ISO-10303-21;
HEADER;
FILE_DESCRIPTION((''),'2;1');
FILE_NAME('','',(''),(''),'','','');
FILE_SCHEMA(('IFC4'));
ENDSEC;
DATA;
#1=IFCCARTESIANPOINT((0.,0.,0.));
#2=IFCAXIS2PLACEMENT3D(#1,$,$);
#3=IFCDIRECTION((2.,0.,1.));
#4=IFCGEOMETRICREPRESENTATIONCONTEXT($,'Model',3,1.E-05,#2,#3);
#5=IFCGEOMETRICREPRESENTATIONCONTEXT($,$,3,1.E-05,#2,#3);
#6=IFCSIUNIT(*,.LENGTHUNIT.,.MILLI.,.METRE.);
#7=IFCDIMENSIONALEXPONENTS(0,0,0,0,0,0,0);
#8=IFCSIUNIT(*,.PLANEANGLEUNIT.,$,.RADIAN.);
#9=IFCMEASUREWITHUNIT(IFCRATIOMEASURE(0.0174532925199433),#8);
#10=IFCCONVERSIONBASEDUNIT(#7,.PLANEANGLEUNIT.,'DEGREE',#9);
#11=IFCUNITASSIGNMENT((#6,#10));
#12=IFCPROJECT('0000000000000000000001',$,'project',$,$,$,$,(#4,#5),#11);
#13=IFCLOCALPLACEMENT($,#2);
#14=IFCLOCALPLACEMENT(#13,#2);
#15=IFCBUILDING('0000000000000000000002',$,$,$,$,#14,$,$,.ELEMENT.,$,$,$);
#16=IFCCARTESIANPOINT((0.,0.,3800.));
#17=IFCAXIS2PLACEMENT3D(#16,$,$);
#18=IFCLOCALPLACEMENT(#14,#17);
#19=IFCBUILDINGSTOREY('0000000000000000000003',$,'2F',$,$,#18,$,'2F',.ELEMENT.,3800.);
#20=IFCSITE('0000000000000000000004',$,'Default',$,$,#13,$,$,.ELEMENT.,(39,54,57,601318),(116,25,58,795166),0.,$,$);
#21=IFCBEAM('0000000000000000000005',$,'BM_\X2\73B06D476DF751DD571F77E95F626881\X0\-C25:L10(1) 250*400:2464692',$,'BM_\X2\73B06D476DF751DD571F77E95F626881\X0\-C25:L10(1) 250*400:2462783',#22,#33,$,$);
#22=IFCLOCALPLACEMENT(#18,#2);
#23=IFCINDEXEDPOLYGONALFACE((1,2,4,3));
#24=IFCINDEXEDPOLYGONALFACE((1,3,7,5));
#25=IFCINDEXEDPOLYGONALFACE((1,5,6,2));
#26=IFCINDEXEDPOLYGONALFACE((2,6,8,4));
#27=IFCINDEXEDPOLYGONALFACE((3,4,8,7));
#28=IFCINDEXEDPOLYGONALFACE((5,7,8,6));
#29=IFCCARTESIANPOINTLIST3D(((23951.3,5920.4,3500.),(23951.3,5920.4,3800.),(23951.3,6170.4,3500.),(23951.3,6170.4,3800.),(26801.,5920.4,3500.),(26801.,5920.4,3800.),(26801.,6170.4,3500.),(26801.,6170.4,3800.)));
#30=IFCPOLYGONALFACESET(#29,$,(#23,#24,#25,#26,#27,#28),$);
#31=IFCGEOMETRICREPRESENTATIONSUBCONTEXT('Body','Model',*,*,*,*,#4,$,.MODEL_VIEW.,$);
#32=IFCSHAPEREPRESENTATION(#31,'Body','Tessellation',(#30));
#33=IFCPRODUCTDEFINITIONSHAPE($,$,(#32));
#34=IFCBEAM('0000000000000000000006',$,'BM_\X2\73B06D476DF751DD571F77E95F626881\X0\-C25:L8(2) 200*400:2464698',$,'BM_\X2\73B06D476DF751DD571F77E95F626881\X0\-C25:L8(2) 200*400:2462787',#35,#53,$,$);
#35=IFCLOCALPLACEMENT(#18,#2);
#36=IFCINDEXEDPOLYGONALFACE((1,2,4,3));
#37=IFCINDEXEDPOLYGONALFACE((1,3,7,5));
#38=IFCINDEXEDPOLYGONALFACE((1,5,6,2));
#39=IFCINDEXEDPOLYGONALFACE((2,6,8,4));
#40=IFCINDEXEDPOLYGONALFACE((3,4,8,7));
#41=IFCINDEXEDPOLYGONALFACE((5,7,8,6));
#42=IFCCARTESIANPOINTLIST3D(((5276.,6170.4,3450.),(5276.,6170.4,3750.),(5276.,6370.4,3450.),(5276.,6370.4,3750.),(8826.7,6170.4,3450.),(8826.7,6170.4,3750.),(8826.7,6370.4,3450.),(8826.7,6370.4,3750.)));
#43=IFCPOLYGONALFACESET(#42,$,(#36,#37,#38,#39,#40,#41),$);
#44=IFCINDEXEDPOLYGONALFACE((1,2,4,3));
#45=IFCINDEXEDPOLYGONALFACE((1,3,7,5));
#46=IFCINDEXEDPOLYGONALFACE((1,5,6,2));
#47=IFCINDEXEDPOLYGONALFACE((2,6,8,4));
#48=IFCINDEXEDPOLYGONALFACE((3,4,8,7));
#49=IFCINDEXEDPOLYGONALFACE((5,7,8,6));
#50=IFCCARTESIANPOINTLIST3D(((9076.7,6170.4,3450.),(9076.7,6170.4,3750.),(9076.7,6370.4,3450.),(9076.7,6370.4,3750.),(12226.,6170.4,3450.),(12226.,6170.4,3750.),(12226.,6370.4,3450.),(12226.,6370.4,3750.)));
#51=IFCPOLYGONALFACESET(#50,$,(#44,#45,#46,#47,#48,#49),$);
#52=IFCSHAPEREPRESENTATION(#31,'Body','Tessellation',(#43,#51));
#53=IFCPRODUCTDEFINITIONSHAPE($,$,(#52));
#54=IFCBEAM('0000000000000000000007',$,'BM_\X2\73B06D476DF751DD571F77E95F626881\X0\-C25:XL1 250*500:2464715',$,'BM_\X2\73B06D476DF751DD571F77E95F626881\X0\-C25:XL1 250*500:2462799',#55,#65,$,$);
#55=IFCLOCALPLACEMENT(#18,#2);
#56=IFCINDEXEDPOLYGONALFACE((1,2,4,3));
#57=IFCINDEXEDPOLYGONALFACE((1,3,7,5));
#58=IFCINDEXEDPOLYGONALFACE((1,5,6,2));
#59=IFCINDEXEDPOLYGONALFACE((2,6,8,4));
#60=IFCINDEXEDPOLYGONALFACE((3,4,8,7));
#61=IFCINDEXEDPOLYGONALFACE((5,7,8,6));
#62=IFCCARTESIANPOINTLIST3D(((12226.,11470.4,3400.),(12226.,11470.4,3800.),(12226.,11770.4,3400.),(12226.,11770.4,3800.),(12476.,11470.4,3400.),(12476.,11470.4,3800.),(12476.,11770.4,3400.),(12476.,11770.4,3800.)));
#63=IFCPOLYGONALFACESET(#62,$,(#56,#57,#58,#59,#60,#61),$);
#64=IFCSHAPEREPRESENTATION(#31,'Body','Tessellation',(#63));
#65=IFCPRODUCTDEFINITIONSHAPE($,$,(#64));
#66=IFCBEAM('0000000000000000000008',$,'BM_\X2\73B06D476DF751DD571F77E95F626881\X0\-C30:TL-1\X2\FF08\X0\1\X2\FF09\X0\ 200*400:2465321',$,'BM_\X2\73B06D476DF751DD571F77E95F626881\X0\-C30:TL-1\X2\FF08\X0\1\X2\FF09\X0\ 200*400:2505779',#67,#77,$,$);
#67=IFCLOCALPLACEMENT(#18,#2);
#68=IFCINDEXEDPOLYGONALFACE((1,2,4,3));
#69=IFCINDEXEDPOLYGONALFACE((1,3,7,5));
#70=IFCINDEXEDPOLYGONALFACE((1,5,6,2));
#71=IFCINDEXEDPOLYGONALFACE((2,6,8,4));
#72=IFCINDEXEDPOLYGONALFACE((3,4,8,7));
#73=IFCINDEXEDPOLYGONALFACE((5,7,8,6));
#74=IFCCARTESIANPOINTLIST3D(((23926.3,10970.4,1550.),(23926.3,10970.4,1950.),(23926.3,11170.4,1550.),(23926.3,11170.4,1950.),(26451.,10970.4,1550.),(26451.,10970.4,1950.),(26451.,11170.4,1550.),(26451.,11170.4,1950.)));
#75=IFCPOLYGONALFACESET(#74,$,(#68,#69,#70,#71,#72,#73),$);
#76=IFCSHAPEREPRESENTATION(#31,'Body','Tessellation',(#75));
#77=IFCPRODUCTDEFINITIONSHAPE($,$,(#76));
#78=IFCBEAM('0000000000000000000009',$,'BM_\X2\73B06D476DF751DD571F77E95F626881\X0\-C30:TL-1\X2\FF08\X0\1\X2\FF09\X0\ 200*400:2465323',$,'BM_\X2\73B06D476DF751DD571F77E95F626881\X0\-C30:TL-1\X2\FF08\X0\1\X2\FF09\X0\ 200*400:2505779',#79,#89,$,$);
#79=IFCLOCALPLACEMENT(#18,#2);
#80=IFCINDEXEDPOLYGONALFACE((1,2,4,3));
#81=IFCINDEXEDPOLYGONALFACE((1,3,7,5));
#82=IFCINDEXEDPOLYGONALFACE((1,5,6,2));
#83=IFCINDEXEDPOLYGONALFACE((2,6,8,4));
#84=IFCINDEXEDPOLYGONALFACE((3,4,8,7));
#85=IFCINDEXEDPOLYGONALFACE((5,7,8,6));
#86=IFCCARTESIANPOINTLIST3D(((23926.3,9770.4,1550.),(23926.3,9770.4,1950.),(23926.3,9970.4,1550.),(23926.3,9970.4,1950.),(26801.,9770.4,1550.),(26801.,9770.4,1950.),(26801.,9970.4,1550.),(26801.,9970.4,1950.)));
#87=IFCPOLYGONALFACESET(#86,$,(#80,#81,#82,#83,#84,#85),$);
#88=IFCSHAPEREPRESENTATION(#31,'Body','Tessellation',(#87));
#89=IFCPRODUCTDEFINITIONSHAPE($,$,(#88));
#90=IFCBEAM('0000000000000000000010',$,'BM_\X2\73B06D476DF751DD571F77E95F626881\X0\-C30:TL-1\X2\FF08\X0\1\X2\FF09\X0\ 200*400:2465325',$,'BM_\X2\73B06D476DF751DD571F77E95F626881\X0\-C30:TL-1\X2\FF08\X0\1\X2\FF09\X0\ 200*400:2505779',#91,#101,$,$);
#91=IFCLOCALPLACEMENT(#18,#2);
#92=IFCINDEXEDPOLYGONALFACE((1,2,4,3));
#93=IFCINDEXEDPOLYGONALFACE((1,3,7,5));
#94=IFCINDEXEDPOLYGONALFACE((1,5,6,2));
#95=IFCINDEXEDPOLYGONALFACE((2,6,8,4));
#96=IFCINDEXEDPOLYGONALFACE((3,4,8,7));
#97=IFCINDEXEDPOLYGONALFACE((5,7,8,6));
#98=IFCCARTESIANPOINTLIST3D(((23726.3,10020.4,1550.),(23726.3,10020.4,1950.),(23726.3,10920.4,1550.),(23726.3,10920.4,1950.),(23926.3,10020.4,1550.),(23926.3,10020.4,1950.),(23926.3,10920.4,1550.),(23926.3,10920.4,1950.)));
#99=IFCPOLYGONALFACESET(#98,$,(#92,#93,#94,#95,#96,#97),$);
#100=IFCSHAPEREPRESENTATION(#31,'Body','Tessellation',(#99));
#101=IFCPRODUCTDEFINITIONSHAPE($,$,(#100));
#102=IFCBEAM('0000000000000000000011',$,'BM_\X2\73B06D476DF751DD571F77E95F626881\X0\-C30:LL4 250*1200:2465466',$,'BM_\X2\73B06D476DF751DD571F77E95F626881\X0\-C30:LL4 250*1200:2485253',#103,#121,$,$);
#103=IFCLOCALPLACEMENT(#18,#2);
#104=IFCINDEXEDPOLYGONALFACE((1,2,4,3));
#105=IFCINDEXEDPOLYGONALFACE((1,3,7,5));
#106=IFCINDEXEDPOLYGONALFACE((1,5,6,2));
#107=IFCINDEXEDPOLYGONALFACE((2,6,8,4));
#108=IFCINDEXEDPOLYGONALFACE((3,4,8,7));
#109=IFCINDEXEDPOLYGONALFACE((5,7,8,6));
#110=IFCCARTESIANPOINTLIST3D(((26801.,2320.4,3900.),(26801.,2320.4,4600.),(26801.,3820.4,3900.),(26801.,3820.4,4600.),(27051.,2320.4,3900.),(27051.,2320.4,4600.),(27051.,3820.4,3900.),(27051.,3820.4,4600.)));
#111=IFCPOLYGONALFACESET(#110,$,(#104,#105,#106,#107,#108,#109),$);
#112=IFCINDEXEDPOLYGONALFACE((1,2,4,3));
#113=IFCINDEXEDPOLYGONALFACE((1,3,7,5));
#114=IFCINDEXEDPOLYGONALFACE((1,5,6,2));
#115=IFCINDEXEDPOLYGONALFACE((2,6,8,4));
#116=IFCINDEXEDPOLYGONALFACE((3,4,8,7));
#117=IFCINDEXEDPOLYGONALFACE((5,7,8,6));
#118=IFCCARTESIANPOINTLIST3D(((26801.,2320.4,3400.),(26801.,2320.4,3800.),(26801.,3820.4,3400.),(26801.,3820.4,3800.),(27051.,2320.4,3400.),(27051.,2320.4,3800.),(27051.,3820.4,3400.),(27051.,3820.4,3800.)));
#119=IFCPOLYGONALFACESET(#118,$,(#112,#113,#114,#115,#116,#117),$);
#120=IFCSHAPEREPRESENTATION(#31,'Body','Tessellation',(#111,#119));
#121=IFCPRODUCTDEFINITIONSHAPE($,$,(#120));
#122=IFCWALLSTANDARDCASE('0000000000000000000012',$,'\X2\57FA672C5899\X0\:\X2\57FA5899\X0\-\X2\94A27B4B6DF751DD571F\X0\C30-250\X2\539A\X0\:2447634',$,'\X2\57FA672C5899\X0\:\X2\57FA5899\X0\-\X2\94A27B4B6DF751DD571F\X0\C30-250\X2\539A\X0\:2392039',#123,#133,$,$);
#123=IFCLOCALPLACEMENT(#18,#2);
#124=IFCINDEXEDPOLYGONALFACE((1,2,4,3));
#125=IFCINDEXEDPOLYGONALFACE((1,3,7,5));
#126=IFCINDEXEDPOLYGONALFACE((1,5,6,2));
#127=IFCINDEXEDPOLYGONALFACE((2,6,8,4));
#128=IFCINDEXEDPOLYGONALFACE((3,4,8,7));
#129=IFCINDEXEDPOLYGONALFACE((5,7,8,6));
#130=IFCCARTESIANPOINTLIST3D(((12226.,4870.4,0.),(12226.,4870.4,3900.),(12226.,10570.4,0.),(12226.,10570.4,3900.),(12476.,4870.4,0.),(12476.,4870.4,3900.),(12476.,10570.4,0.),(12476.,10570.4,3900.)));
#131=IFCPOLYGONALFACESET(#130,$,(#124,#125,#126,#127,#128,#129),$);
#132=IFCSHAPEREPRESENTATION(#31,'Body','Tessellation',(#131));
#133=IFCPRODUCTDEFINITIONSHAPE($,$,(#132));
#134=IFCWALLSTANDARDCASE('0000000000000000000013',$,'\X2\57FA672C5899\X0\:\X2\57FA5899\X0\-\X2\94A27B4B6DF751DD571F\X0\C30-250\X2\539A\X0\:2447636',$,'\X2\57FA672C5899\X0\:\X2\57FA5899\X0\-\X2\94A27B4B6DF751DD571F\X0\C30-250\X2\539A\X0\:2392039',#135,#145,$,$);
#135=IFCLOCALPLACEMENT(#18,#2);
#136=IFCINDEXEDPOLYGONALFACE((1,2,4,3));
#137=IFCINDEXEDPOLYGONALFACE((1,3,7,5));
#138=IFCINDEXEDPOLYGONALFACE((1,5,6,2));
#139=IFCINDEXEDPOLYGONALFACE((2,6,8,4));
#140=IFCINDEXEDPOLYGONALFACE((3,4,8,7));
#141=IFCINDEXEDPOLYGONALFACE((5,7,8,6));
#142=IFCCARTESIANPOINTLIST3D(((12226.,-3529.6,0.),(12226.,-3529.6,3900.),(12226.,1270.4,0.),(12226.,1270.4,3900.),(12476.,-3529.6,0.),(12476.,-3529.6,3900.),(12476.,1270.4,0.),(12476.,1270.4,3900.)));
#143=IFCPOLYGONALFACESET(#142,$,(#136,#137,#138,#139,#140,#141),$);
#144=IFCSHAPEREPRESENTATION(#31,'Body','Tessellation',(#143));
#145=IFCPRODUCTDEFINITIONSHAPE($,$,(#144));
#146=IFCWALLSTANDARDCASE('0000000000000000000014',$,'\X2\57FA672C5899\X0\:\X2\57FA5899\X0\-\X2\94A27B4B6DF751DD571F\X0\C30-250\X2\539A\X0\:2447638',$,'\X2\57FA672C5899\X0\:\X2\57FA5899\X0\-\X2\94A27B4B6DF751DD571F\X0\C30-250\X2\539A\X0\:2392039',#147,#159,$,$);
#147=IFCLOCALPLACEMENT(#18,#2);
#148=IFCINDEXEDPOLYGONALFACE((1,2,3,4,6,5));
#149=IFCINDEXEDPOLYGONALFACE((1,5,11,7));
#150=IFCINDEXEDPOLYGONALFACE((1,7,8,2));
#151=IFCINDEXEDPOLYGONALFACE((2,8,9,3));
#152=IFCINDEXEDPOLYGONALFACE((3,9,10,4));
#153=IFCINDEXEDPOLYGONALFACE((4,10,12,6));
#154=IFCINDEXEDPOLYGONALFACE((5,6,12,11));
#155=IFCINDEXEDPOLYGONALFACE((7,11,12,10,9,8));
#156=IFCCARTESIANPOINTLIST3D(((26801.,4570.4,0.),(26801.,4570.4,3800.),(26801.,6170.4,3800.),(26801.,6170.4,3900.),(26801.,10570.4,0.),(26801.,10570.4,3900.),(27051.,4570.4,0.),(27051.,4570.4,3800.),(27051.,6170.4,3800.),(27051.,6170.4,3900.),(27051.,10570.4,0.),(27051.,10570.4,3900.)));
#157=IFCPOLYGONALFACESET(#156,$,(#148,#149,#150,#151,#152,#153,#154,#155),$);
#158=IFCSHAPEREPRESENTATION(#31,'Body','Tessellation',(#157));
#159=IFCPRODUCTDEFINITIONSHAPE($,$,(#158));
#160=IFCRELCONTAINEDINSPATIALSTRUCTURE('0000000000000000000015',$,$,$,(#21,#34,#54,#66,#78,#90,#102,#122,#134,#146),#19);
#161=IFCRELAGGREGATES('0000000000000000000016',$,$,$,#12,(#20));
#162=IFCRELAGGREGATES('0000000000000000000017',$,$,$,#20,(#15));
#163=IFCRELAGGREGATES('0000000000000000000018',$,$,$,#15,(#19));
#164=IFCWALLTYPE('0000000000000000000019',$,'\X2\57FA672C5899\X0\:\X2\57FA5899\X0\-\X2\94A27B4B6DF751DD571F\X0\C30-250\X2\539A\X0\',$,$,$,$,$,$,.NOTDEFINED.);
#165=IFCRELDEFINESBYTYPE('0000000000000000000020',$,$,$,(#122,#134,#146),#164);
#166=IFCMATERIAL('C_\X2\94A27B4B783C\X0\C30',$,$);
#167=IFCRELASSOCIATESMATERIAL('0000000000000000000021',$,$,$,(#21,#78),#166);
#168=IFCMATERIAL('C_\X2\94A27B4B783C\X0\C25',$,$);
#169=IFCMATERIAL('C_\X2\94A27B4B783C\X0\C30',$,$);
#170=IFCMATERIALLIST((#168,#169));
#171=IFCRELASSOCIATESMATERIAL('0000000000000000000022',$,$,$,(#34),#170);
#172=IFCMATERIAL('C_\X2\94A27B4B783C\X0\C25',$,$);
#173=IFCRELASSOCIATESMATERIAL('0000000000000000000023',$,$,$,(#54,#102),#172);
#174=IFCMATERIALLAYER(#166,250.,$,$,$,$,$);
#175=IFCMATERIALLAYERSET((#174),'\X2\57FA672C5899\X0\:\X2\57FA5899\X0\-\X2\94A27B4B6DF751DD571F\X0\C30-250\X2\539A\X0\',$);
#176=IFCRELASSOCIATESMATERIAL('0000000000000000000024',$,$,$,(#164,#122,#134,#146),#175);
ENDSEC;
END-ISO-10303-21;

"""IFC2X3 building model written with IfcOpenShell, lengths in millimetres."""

from ifc_helpers import new_model, entity, si_unit, converted_unit, direction, frame, frame_2d, origin, origin_2d_with_axis, place, context, subcontext, project, spatial, polyline, rectangle, extrude, clip, bounded_halfspace, material, material_list, layer, layer_set, layer_usage, type_object, element, save


model = new_model("IFC2X3")

# Units and contexts
model_context = context("Model", 3, precision=1e-05, world=origin(), true_north=direction((2.0, 0.0, 1.0)))
context_of_model = context(None, 3, precision=1e-05, world=origin(), true_north=direction((2.0, 0.0, 1.0)))
body_context = subcontext(model_context, "Body", "Model", "MODEL_VIEW")
ifc_project = project(units=[si_unit("LENGTHUNIT", "METRE", prefix="MILLI"), converted_unit("PLANEANGLEUNIT", "DEGREE", entity("IfcRatioMeasure", 0.0174532925199433), si_unit("PLANEANGLEUNIT", "RADIAN"), dimensions=[0, 0, 0, 0, 0, 0, 0])], contexts=[model_context, context_of_model])

# Site, building, storey
site_placement = place(None, origin())
site = spatial("IfcSite", under=ifc_project, at=site_placement, Name="Default", CompositionType="ELEMENT", RefLatitude=(39, 54, 57, 601318), RefLongitude=(116, 25, 58, 795166), RefElevation=0.0)
building_placement = place(site_placement, origin())
building = spatial("IfcBuilding", under=site, at=building_placement, CompositionType="ELEMENT")
storey_placement = place(building_placement, frame((0.0, 0.0, 3800.0)))
storey = spatial("IfcBuildingStorey", under=building, at=storey_placement, Name="2F", LongName="2F", CompositionType="ELEMENT", Elevation=3800.0)

# Beams
ifc_material_1 = material(Name="C_钢筋砼C25")
ifc_material_2 = material(Name="C_钢筋砼C30")
beam_1_placement = place(storey_placement, frame((23826.3, 6045.4, 3900.0)))
element("IfcBeam", 1, at=beam_1_placement, inside=storey, material=ifc_material_2, Name="BM_现浇混凝土矩形梁-C25:L10(1) 250*400:2464692", ObjectType="BM_现浇混凝土矩形梁-C25:L10(1) 250*400:2462783", context=body_context, shape_type="SweptSolid", body=[
    extrude(rectangle(XDim=300.0, YDim=250.0, at=frame_2d((0.0, 0.0), x_axis=(1.0, 0.0))), frame((125.0, 0.0, -250.0), z_axis=(1.0, 0.0, 0.0), x_axis=(0.0, 0.0, -1.0)), (0.0, 0.0, 1.0), 2849.6),
])
ifc_material_3 = material(Name="C_钢筋砼C25")
ifc_material_4 = material(Name="C_钢筋砼C30")
ifc_material_list = material_list([ifc_material_3, ifc_material_4])
beam_2_placement = place(storey_placement, frame((5151.0, 6270.4, 3850.0)))
element("IfcBeam", 2, at=beam_2_placement, inside=storey, material=ifc_material_list, Name="BM_现浇混凝土矩形梁-C25:L8(2) 200*400:2464698", ObjectType="BM_现浇混凝土矩形梁-C25:L8(2) 200*400:2462787", context=body_context, shape_type="SweptSolid", body=[
    extrude(rectangle(XDim=300.0, YDim=200.0, at=frame_2d((0.0, 0.0), x_axis=(1.0, 0.0))), frame((125.0, 0.0, -250.0), z_axis=(1.0, 0.0, 0.0), x_axis=(0.0, 0.0, 1.0)), (0.0, 0.0, 1.0), 3550.7),
    extrude(rectangle(XDim=300.0, YDim=200.0, at=frame_2d((0.0, 0.0), x_axis=(1.0, 0.0))), frame((3925.7, 0.0, -250.0), z_axis=(1.0, 0.0, 0.0), x_axis=(0.0, 0.0, 1.0)), (0.0, 0.0, 1.0), 3149.3),
])
beam_3_placement = place(storey_placement, frame((12351.0, 11170.4, 3900.0), z_axis=(0.0, 0.0, 1.0), x_axis=(0.0, 1.0, 0.0)))
element("IfcBeam", 3, at=beam_3_placement, inside=storey, material=ifc_material_1, Name="BM_现浇混凝土矩形梁-C25:XL1 250*500:2464715", ObjectType="BM_现浇混凝土矩形梁-C25:XL1 250*500:2462799", context=body_context, shape_type="SweptSolid", body=[
    extrude(rectangle(XDim=400.0, YDim=250.0, at=frame_2d((0.0, 0.0), x_axis=(1.0, 0.0))), frame((300.0, 0.0, -300.0), z_axis=(1.0, 0.0, 0.0), x_axis=(0.0, 0.0, -1.0)), (0.0, 0.0, 1.0), 300.0),
])
beam_4_placement = place(storey_placement, frame((23863.8, 11070.4, 1950.0)))
element("IfcBeam", 4, at=beam_4_placement, inside=storey, Name="BM_现浇混凝土矩形梁-C30:TL-1（1） 200*400:2465321", ObjectType="BM_现浇混凝土矩形梁-C30:TL-1（1） 200*400:2505779", context=body_context, shape_type="SweptSolid", body=[
    extrude(rectangle(XDim=400.0, YDim=200.0, at=frame_2d((0.0, 0.0), x_axis=(1.0, 0.0))), frame((62.5, 0.0, -200.0), z_axis=(1.0, 0.0, 0.0), x_axis=(0.0, 0.0, -1.0)), (0.0, 0.0, 1.0), 2524.6),
])
beam_5_placement = place(storey_placement, frame((23863.8, 9870.4, 1950.0)))
element("IfcBeam", 5, at=beam_5_placement, inside=storey, material=ifc_material_2, Name="BM_现浇混凝土矩形梁-C30:TL-1（1） 200*400:2465323", ObjectType="BM_现浇混凝土矩形梁-C30:TL-1（1） 200*400:2505779", context=body_context, shape_type="SweptSolid", body=[
    extrude(rectangle(XDim=400.0, YDim=200.0, at=frame_2d((0.0, 0.0), x_axis=(1.0, 0.0))), frame((62.5, 0.0, -200.0), z_axis=(1.0, 0.0, 0.0), x_axis=(0.0, 0.0, -1.0)), (0.0, 0.0, 1.0), 2874.6),
])
beam_6_placement = place(storey_placement, frame((23826.3, 11195.4, 1950.0), z_axis=(0.0, 0.0, 1.0), x_axis=(0.0, -1.0, 0.0)))
element("IfcBeam", 6, at=beam_6_placement, inside=storey, Name="BM_现浇混凝土矩形梁-C30:TL-1（1） 200*400:2465325", ObjectType="BM_现浇混凝土矩形梁-C30:TL-1（1） 200*400:2505779", context=body_context, shape_type="SweptSolid", body=[
    extrude(rectangle(XDim=400.0, YDim=200.0, at=origin_2d_with_axis()), frame((275.0, 0.0, -200.0), z_axis=(1.0, 0.0, 0.0), x_axis=(0.0, 0.0, -1.0)), (0.0, 0.0, 1.0), 900.0),
])
beam_7_placement = place(storey_placement, frame((26926.0, 3820.4, 4600.0), z_axis=(0.0, 0.0, 1.0), x_axis=(0.0, -1.0, 0.0)))
element("IfcBeam", 7, at=beam_7_placement, inside=storey, material=ifc_material_1, Name="BM_现浇混凝土矩形梁-C30:LL4 250*1200:2465466", ObjectType="BM_现浇混凝土矩形梁-C30:LL4 250*1200:2485253", context=body_context, shape_type="SweptSolid", body=[
    extrude(rectangle(XDim=700.0, YDim=250.0, at=frame_2d((0.0, 0.0), x_axis=(1.0, 0.0))), frame((0.0, 0.0, -350.0), z_axis=(1.0, 0.0, 0.0), x_axis=(0.0, 0.0, -1.0)), (0.0, 0.0, 1.0), 1500.0),
    extrude(rectangle(XDim=400.0, YDim=250.0, at=frame_2d((0.0, 0.0), x_axis=(1.0, 0.0))), frame((0.0, 0.0, -1000.0), z_axis=(1.0, 0.0, 0.0), x_axis=(0.0, 0.0, 1.0)), (0.0, 0.0, 1.0), 1500.0),
])

# Walls
ifc_layer = layer(ifc_material_2, 250.0)
ifc_layer_set = layer_set([ifc_layer], Name="基本墙:基墙-钢筋混凝土C30-250厚")
ifc_layer_usage_1 = layer_usage(ifc_layer_set, "AXIS2", "NEGATIVE", 125.0)
wall_type = type_object("IfcWallType", Name="基本墙:基墙-钢筋混凝土C30-250厚", PredefinedType="NOTDEFINED", material=ifc_layer_set)
wall_1_placement = place(storey_placement, frame((12351.0, 10570.4, 0.0), z_axis=(0.0, 0.0, 1.0), x_axis=(0.0, -1.0, 0.0)))
element("IfcWallStandardCase", 8, at=wall_1_placement, inside=storey, type_object=wall_type, material=ifc_layer_usage_1, Name="基本墙:基墙-钢筋混凝土C30-250厚:2447634", ObjectType="基本墙:基墙-钢筋混凝土C30-250厚:2392039", context=body_context, shape_type="Clipping", body=[
    clip(clip(extrude(rectangle(XDim=5700.0, YDim=250.0, at=frame_2d((2850.0, 0.0), x_axis=(-1.0, 0.0))), origin(), (0.0, 0.0, 1.0), 3900.0), bounded_halfspace(frame((0.0, -125.0, 0.0), z_axis=(1.0, 0.0, 0.0), x_axis=(0.0, 0.0, -1.0)), True, frame((0.0, -125.0, 0.0), z_axis=(1.0, 0.0, 0.0), x_axis=(0.0, 0.0, -1.0)), polyline([(0.0, 0.0), (0.0, 250.0), (-3800.0, 250.0), (-3900.0, 250.0), (-3900.0, 0.0), (-3800.0, 0.0), (0.0, 0.0)]))), bounded_halfspace(frame((5700.0, -125.0, 3900.0), z_axis=(-1.0, 0.0, 0.0), x_axis=(0.0, 0.0, -1.0)), True, frame((5700.0, -125.0, 3900.0), z_axis=(-1.0, 0.0, 0.0), x_axis=(0.0, 0.0, -1.0)), polyline([(0.0, 0.0), (0.0, -250.0), (100.0, -250.0), (3900.0, -250.0), (3900.0, 0.0), (100.0, 0.0), (0.0, 0.0)]))),
])
ifc_layer_usage_2 = layer_usage(ifc_layer_set, "AXIS2", "NEGATIVE", 125.0)
wall_2_placement = place(storey_placement, frame((12351.0, 1270.4, 0.0), z_axis=(0.0, 0.0, 1.0), x_axis=(0.0, -1.0, 0.0)))
element("IfcWallStandardCase", 9, at=wall_2_placement, inside=storey, type_object=wall_type, material=ifc_layer_usage_2, Name="基本墙:基墙-钢筋混凝土C30-250厚:2447636", ObjectType="基本墙:基墙-钢筋混凝土C30-250厚:2392039", context=body_context, shape_type="Clipping", body=[
    clip(clip(extrude(rectangle(XDim=4800.0, YDim=250.0, at=frame_2d((2400.0, 0.0), x_axis=(-1.0, 0.0))), origin(), (0.0, 0.0, 1.0), 3900.0), bounded_halfspace(frame((4800.0, -125.0, 3900.0), z_axis=(1.0, 0.0, 0.0), x_axis=(0.0, 0.0, -1.0)), False, frame((4800.0, -125.0, 3900.0), z_axis=(1.0, 0.0, 0.0), x_axis=(0.0, 0.0, -1.0)), polyline([(0.0, 0.0), (100.0, 0.0), (3900.0, 0.0), (3900.0, 250.0), (100.0, 250.0), (0.0, 250.0), (0.0, 0.0)]))), bounded_halfspace(frame((0.0, -125.0, 0.0), z_axis=(1.0, 0.0, 0.0), x_axis=(0.0, 0.0, -1.0)), True, frame((0.0, -125.0, 0.0), z_axis=(1.0, 0.0, 0.0), x_axis=(0.0, 0.0, -1.0)), polyline([(0.0, 0.0), (0.0, 250.0), (-3800.0, 250.0), (-3900.0, 250.0), (-3900.0, 0.0), (-3800.0, 0.0), (0.0, 0.0)]))),
])
ifc_layer_usage_3 = layer_usage(ifc_layer_set, "AXIS2", "NEGATIVE", 125.0)
wall_3_placement = place(storey_placement, frame((26926.0, 10570.4, 0.0), z_axis=(0.0, 0.0, 1.0), x_axis=(0.0, -1.0, 0.0)))
element("IfcWallStandardCase", 10, at=wall_3_placement, inside=storey, type_object=wall_type, material=ifc_layer_usage_3, Name="基本墙:基墙-钢筋混凝土C30-250厚:2447638", ObjectType="基本墙:基墙-钢筋混凝土C30-250厚:2392039", context=body_context, shape_type="Clipping", body=[
    clip(clip(clip(clip(extrude(rectangle(XDim=6000.0, YDim=250.0, at=frame_2d((3000.0, 0.0), x_axis=(-1.0, 0.0))), origin(), (0.0, 0.0, 1.0), 3900.0), bounded_halfspace(frame((6000.0, -125.0, 0.0), z_axis=(1.0, 0.0, 0.0), x_axis=(0.0, 0.0, -1.0)), False, frame((6000.0, -125.0, 0.0), z_axis=(1.0, 0.0, 0.0), x_axis=(0.0, 0.0, -1.0)), polyline([(0.0, 0.0), (0.0, 250.0), (-3800.0, 250.0), (-3800.0, 0.0), (0.0, 0.0)]))), bounded_halfspace(frame((0.0, -125.0, 0.0), z_axis=(-1.0, 0.0, 0.0), x_axis=(0.0, 0.0, -1.0)), False, frame((0.0, -125.0, 0.0), z_axis=(-1.0, 0.0, 0.0), x_axis=(0.0, 0.0, -1.0)), polyline([(0.0, 0.0), (-3900.0, 0.0), (-3900.0, -250.0), (0.0, -250.0), (0.0, 0.0)]))), bounded_halfspace(frame((4400.0, 125.0, 3800.0), z_axis=(0.0, 0.0, -1.0), x_axis=(-1.0, 0.0, 0.0)), True, frame((4400.0, 125.0, 3800.0), z_axis=(0.0, 0.0, -1.0), x_axis=(-1.0, 0.0, 0.0)), polyline([(0.0, 0.0), (-1600.0, 0.0), (-1600.0, -250.0), (0.0, -250.0), (0.0, 0.0)]))), bounded_halfspace(frame((4400.0, -125.0, 3800.0), z_axis=(-1.0, 0.0, 0.0), x_axis=(0.0, 0.0, 1.0)), True, frame((4400.0, -125.0, 3800.0), z_axis=(-1.0, 0.0, 0.0), x_axis=(0.0, 0.0, 1.0)), polyline([(0.0, 0.0), (100.0, 0.0), (100.0, 250.0), (0.0, 250.0), (0.0, 0.0)]))),
])

save(model, "model.ifc")
